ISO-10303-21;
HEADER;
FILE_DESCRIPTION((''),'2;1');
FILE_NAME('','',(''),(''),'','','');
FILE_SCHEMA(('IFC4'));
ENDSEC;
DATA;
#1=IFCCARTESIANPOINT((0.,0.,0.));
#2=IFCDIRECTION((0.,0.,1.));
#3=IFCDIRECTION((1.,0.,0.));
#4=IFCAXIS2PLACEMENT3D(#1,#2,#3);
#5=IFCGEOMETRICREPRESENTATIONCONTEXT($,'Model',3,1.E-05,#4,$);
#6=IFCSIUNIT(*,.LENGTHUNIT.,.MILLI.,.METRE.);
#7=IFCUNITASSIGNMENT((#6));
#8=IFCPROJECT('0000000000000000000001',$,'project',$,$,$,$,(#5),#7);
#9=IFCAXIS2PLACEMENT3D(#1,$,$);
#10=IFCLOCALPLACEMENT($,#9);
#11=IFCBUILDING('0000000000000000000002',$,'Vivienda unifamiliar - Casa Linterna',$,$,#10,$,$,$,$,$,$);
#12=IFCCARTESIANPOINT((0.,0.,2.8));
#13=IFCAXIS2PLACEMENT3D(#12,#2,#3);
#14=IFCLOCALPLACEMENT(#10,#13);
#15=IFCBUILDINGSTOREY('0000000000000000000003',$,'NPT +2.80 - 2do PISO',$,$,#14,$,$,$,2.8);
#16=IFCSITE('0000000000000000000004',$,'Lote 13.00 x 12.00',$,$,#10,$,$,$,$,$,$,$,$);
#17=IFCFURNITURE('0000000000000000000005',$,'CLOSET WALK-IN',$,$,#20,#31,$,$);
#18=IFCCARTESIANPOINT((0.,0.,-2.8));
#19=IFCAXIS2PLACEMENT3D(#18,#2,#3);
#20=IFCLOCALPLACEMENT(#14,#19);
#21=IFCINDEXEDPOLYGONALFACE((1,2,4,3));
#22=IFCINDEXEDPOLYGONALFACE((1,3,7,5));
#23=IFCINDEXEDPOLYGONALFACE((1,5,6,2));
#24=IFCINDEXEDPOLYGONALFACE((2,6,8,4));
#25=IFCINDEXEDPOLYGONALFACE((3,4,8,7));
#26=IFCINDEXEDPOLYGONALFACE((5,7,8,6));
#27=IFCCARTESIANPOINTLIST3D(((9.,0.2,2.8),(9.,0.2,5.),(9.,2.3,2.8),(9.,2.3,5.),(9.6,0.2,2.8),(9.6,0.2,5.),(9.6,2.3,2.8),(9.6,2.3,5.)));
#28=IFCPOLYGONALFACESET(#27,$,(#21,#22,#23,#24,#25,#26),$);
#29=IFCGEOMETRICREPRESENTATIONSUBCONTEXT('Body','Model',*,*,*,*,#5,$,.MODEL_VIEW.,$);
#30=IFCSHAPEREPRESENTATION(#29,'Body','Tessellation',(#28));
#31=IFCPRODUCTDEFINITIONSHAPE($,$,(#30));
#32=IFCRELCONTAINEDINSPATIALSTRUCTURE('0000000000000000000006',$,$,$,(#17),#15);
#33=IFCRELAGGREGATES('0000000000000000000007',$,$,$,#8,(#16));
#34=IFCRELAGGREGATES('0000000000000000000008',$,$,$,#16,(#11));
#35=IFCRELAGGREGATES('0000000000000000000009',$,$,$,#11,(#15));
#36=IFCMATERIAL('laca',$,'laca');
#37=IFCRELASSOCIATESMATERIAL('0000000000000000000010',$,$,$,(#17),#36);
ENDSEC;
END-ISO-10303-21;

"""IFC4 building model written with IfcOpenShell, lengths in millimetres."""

from ifc_helpers import new_model, si_unit, frame, origin, origin_with_axes, place, context, subcontext, project, spatial, polyline, outline, extrude, material, element, save


model = new_model("IFC4")

# Units and contexts
model_context = context("Model", 3, precision=1e-05, world=origin_with_axes())
body_context = subcontext(model_context, "Body", "Model", "MODEL_VIEW")
ifc_project = project(units=[si_unit("LENGTHUNIT", "METRE", prefix="MILLI")], contexts=[model_context])

# Site, building, storey
placement = place(None, origin())
site = spatial("IfcSite", under=ifc_project, at=placement, Name="Lote 13.00 x 12.00")
building = spatial("IfcBuilding", under=site, at=placement, Name="Vivienda unifamiliar - Casa Linterna")
storey_placement = place(placement, frame((0.0, 0.0, 2.8), z_axis=(0.0, 0.0, 1.0), x_axis=(1.0, 0.0, 0.0)))
storey = spatial("IfcBuildingStorey", under=building, at=storey_placement, Name="NPT +2.80 - 2do PISO", Elevation=2.8)

# Furniture
ifc_material_1 = material(Name="laca", Category="laca")
furniture_1_placement = place(storey_placement, frame((0.0, 0.0, -2.8), z_axis=(0.0, 0.0, 1.0), x_axis=(1.0, 0.0, 0.0)))
element("IfcFurniture", 1, at=furniture_1_placement, inside=storey, material=ifc_material_1, Name="CLOSET WALK-IN", context=body_context, shape_type="SweptSolid", body=[
    extrude(outline(polyline([(0.2, 2.8), (2.3, 2.8), (2.3, 5.0), (0.2, 5.0), (0.2, 2.8)])), frame((9.0, 0.0, 0.0), z_axis=(1.0, 0.0, 0.0), x_axis=(0.0, 1.0, 0.0)), (0.0, 0.0, 1.0), 0.6),
])

save(model, "model.ifc")
